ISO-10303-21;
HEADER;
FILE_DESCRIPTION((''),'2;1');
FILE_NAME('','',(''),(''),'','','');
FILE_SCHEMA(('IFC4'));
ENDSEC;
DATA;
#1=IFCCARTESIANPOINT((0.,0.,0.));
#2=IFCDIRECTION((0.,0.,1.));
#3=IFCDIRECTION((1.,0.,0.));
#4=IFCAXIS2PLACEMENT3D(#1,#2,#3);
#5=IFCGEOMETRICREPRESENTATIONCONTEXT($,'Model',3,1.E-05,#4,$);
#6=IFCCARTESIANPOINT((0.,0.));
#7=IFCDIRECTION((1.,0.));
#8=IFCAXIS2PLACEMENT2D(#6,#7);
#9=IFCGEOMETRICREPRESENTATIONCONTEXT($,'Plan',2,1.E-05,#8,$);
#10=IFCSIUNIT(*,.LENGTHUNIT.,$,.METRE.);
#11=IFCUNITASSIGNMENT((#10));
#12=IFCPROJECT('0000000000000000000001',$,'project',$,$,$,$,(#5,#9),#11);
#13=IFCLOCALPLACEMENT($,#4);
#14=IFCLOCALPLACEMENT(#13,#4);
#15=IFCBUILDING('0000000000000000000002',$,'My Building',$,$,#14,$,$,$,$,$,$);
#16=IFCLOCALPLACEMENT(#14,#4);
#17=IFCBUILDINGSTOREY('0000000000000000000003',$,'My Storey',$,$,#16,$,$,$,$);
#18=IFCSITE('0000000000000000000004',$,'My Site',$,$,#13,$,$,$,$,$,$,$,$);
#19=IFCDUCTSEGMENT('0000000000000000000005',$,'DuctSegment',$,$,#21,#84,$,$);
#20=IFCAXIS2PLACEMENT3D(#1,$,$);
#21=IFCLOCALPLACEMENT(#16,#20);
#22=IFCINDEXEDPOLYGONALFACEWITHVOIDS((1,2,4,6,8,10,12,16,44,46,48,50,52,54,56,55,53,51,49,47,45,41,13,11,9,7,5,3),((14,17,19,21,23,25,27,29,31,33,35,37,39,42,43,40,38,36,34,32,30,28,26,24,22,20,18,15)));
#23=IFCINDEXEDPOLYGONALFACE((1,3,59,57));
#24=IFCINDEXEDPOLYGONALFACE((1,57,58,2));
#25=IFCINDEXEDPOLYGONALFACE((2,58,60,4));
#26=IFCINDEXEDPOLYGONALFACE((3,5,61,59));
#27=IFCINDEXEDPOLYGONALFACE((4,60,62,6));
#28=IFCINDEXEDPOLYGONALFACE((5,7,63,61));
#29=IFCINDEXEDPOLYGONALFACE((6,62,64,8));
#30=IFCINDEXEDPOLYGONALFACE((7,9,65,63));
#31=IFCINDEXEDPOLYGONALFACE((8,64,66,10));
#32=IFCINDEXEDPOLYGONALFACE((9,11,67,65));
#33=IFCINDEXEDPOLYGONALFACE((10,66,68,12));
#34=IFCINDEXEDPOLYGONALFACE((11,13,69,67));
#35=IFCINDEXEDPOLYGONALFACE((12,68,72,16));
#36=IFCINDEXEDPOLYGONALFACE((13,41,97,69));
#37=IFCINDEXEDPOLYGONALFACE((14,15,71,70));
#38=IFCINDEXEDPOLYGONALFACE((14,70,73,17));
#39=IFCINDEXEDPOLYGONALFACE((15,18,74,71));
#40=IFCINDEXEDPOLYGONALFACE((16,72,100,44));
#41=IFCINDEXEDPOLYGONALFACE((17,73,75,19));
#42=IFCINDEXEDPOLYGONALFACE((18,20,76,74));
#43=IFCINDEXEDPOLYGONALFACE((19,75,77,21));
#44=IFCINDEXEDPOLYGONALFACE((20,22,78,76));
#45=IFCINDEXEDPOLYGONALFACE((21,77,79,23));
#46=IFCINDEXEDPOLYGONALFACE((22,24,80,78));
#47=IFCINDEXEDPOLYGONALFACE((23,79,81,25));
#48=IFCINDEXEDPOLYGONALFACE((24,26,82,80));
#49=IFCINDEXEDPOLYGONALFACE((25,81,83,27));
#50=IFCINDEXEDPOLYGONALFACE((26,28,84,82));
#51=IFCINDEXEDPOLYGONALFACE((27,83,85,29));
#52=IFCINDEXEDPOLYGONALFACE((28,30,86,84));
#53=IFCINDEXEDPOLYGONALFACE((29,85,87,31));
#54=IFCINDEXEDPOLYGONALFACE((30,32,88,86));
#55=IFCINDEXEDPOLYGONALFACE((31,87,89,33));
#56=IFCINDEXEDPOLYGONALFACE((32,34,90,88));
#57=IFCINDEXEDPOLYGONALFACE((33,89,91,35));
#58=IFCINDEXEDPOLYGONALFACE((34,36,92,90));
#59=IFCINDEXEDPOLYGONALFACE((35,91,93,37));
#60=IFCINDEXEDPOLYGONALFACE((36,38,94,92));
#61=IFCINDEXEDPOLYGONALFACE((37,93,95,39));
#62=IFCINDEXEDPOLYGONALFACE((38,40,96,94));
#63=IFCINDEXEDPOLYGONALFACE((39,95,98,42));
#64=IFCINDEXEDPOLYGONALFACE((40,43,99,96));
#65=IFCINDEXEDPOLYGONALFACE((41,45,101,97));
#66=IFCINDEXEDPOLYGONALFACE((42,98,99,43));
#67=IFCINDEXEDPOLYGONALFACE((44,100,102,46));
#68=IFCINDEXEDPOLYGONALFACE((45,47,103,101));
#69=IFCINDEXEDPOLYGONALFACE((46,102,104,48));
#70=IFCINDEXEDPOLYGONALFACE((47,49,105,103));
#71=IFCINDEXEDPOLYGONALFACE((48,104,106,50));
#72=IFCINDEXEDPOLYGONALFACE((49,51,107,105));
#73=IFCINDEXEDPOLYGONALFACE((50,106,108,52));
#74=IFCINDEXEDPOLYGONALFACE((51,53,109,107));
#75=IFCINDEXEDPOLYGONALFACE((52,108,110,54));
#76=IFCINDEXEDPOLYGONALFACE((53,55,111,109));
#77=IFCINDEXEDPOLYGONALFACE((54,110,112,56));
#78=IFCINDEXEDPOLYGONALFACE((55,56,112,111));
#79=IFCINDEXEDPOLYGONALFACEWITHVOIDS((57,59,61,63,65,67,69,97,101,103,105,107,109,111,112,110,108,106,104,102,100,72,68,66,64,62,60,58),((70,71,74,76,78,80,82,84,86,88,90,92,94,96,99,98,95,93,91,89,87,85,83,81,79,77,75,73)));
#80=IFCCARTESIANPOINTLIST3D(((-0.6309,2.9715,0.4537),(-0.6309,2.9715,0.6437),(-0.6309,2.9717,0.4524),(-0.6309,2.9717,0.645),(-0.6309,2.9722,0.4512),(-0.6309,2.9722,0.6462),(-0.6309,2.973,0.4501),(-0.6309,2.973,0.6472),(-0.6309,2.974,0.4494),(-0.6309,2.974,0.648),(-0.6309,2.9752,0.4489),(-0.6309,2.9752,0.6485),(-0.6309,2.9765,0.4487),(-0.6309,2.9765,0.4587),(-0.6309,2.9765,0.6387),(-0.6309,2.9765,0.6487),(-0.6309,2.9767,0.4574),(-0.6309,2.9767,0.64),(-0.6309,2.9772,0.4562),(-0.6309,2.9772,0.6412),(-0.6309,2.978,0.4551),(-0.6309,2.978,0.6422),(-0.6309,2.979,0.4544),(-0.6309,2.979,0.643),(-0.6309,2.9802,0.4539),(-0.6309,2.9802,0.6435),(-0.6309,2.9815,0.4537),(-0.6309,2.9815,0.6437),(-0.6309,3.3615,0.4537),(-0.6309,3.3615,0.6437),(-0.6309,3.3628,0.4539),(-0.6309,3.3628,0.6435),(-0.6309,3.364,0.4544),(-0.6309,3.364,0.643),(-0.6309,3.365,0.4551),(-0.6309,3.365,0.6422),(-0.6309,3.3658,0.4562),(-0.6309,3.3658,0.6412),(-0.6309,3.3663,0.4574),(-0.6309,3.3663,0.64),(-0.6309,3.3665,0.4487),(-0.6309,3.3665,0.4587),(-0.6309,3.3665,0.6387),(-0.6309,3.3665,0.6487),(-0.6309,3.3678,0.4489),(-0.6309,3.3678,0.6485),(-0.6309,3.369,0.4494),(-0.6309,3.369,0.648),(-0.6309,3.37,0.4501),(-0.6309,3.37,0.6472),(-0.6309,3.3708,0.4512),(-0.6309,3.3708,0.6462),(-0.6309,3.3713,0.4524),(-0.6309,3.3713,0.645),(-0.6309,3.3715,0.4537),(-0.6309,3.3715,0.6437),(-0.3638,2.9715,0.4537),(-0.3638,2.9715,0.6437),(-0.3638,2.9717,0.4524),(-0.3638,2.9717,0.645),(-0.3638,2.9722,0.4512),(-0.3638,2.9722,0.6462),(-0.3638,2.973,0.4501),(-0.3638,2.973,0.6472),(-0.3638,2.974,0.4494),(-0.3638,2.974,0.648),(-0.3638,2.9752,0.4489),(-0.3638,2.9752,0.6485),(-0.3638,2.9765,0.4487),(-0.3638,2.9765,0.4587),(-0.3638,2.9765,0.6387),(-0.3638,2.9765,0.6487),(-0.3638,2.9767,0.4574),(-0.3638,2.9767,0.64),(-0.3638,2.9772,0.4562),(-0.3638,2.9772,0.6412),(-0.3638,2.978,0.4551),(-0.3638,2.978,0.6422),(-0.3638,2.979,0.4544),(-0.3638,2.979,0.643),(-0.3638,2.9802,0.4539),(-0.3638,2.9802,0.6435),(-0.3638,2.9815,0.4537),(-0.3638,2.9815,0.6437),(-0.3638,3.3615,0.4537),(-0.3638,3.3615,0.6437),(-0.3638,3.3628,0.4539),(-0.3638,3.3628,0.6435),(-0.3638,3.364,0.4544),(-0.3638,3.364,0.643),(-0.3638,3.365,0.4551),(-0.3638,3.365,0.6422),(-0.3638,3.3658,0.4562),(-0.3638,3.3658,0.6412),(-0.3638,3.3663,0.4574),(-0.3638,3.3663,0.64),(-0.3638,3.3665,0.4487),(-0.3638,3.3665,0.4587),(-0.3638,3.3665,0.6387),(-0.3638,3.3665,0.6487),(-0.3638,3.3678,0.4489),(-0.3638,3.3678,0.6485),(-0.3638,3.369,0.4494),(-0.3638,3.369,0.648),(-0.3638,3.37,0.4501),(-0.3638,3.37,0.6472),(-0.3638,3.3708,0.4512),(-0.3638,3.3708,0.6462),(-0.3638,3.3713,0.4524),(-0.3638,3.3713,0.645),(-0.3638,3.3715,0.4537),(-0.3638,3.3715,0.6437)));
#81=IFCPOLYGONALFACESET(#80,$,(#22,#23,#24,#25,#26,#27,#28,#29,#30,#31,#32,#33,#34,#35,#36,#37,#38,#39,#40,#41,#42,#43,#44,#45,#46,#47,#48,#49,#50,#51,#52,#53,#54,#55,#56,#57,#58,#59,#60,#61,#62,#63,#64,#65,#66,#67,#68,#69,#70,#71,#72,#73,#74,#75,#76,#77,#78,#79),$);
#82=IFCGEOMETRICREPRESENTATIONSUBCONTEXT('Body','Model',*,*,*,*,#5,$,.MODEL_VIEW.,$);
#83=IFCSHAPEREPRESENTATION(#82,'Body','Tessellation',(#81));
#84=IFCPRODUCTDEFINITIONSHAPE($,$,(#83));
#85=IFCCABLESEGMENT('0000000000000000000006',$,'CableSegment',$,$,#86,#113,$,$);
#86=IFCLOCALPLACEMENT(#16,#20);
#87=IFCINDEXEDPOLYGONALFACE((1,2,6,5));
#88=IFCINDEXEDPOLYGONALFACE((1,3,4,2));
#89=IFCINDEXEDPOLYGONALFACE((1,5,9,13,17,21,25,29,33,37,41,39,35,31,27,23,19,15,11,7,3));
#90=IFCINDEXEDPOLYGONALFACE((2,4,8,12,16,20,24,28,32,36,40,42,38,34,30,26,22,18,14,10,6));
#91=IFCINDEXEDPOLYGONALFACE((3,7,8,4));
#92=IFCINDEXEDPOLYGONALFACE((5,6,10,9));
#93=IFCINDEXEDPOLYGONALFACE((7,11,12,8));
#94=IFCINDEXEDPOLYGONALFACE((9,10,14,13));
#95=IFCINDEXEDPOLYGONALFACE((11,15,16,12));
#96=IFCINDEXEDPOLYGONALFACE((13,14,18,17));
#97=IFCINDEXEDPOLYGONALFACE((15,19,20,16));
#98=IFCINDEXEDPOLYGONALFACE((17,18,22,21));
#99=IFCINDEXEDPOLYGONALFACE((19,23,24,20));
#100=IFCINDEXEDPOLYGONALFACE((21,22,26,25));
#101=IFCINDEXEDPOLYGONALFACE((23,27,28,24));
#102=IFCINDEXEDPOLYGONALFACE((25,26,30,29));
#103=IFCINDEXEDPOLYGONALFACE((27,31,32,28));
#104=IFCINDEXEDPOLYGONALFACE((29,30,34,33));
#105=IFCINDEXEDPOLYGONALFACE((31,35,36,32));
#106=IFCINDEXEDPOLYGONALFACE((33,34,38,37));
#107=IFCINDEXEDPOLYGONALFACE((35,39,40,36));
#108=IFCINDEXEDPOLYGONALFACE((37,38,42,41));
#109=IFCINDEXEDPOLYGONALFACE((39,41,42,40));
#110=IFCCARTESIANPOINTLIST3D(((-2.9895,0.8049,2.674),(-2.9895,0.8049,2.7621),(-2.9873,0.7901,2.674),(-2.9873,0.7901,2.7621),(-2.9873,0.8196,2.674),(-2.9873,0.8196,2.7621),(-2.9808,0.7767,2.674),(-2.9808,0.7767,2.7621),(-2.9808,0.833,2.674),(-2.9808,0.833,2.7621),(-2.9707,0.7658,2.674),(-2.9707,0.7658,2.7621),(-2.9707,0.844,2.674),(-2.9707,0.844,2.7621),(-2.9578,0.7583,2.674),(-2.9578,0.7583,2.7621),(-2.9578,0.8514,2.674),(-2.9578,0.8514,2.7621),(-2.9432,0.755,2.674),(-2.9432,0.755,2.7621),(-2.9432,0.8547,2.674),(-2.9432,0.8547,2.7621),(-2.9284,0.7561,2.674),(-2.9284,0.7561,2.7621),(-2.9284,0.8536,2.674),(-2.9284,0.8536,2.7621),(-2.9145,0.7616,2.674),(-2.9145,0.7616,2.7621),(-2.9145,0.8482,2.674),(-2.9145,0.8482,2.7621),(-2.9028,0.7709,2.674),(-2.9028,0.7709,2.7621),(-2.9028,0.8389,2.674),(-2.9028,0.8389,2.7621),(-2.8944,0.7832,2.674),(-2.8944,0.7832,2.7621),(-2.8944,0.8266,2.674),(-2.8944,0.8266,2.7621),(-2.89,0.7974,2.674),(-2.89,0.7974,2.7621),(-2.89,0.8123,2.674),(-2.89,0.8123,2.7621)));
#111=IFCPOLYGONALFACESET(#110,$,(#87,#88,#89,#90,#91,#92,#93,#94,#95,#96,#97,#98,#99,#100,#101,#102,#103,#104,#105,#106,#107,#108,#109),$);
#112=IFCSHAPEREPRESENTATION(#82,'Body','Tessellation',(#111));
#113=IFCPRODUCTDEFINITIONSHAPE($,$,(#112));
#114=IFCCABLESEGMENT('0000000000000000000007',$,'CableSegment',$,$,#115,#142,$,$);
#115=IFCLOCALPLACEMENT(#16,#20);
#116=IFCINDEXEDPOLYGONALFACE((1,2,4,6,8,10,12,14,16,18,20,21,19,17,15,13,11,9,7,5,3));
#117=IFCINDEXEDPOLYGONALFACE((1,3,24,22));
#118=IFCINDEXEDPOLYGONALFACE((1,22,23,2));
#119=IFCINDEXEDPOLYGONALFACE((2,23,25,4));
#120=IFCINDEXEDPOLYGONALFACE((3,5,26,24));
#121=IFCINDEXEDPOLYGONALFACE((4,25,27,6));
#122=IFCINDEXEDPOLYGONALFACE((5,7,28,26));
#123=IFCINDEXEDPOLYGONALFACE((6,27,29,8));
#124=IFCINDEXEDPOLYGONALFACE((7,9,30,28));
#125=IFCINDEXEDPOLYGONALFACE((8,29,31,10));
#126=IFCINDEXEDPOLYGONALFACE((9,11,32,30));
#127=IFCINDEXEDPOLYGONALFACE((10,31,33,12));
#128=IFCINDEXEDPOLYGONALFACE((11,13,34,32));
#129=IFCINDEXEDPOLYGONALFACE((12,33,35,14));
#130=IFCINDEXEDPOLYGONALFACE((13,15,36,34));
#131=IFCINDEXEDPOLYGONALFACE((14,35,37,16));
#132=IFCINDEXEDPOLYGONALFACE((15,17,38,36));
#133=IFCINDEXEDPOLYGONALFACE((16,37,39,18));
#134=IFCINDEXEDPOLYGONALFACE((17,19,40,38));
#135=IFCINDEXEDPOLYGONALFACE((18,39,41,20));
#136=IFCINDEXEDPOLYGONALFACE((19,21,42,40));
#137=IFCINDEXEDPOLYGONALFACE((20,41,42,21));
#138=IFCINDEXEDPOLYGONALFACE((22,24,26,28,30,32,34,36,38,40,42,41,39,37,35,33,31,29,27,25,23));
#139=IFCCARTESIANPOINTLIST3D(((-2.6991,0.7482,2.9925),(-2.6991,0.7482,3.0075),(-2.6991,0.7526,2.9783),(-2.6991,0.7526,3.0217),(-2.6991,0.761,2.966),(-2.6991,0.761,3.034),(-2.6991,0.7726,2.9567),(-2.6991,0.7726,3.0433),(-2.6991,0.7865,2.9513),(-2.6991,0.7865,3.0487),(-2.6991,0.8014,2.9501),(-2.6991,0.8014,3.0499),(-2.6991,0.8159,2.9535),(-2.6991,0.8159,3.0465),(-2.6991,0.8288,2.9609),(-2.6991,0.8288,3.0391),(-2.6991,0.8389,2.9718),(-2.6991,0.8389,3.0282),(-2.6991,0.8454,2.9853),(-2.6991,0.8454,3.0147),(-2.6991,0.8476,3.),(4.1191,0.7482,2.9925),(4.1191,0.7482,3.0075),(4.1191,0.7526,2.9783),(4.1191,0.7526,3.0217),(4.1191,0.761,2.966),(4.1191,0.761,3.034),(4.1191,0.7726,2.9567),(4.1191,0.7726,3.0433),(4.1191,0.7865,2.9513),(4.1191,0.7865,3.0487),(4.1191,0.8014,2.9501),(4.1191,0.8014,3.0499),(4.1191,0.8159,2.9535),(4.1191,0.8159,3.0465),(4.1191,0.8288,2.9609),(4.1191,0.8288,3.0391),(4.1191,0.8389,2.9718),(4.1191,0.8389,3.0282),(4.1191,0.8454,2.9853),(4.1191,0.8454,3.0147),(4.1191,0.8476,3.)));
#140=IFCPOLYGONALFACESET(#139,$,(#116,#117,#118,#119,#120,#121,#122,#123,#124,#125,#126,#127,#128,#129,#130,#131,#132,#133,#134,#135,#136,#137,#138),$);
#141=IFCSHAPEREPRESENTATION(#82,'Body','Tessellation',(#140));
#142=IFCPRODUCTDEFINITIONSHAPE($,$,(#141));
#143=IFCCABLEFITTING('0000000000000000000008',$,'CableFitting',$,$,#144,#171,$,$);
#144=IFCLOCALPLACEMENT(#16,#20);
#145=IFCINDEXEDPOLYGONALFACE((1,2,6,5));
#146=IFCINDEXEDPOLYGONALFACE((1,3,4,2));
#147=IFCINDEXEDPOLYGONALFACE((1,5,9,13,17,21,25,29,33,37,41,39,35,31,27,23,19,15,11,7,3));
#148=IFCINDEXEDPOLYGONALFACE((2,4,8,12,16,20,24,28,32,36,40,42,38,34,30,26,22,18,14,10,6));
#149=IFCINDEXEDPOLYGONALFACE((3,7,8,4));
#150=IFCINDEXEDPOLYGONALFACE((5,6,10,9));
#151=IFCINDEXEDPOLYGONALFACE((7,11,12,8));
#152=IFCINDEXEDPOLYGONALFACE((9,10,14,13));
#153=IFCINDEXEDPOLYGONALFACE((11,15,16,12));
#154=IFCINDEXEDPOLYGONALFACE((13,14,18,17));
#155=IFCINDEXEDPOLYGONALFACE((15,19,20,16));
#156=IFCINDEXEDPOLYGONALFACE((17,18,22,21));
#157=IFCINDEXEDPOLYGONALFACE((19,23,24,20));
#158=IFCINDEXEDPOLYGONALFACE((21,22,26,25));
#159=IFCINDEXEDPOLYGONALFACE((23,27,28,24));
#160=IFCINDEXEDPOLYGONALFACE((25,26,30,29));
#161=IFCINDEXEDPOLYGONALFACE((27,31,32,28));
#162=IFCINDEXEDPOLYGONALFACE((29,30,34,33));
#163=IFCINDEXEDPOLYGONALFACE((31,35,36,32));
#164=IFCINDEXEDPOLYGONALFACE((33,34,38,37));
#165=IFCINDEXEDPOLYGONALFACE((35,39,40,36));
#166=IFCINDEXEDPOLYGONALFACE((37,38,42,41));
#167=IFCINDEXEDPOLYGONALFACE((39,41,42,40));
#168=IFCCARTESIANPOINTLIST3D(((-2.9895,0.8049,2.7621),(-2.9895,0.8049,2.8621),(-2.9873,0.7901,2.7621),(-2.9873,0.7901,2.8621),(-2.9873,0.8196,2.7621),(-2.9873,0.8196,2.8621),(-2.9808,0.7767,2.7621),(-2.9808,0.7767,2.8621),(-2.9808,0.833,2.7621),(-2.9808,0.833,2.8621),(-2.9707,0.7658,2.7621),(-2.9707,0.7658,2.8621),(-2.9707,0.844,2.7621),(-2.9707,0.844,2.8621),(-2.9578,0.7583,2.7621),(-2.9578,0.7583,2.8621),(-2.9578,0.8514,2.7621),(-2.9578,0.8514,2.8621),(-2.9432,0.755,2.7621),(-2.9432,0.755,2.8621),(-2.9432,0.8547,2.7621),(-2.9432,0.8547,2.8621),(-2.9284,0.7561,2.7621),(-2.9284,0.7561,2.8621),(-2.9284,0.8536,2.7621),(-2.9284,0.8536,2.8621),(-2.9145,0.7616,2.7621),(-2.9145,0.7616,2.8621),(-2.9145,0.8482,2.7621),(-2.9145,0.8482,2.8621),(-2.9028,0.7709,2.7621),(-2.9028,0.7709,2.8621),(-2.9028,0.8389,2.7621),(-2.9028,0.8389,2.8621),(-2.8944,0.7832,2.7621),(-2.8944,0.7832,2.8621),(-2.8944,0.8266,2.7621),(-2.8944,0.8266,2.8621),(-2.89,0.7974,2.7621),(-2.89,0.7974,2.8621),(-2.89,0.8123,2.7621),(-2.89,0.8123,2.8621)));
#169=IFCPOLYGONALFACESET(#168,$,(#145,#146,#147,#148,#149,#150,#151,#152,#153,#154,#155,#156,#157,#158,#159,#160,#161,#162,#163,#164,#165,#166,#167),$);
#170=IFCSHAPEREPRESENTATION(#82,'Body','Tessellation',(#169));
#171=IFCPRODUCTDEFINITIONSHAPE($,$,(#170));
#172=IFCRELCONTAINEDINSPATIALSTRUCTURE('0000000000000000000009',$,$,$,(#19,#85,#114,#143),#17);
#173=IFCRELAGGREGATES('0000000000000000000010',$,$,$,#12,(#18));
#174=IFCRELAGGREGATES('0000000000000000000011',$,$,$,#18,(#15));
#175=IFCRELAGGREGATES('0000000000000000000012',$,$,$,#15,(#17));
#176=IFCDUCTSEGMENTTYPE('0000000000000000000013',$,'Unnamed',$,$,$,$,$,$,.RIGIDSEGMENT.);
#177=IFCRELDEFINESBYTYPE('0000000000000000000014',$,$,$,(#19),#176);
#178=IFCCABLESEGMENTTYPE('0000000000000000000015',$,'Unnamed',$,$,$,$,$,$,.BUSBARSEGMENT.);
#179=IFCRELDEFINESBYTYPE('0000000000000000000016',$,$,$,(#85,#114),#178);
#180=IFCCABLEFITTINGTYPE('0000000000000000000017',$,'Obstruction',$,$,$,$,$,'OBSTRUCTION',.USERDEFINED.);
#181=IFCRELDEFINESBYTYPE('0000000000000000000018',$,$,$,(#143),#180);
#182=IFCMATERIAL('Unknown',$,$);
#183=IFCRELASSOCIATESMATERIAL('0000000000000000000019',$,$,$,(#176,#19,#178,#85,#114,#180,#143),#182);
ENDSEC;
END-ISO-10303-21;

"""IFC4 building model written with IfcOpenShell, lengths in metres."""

from ifc_helpers import new_model, si_unit, frame, origin_with_axes, origin_2d_with_axis, place, context, subcontext, project, spatial, hollow_rectangle, circle, extrude, material, material_profile, profile_set, profile_usage, type_object, element, save


model = new_model("IFC4")

# Units and contexts
model_context = context("Model", 3, precision=1e-05, world=origin_with_axes())
plan_context = context("Plan", 2, precision=1e-05, world=origin_2d_with_axis())
body_context_1 = subcontext(model_context, "Body", "Model", "MODEL_VIEW")
ifc_project = project(units=[si_unit("LENGTHUNIT", "METRE")], contexts=[model_context, plan_context])

# Site, building, storey
site_placement = place(None, origin_with_axes())
site = spatial("IfcSite", under=ifc_project, at=site_placement, Name="My Site")
building_placement = place(site_placement, origin_with_axes())
building = spatial("IfcBuilding", under=site, at=building_placement, Name="My Building")
storey_placement = place(building_placement, origin_with_axes())
storey = spatial("IfcBuildingStorey", under=building, at=storey_placement, Name="My Storey")

# Shared definitions
ifc_material = material(Name="Unknown")

# Duct segment
ifc_material_profile_1 = material_profile(ifc_material, hollow_rectangle(XDim=0.4, YDim=0.2, WallThickness=0.005, InnerFilletRadius=0.005, OuterFilletRadius=0.005))
ifc_profile_set_1 = profile_set([ifc_material_profile_1])
duct_segment_type = type_object("IfcDuctSegmentType", Name="Unnamed", PredefinedType="RIGIDSEGMENT", material=ifc_profile_set_1)
ifc_profile_usage_1 = profile_usage(ifc_profile_set_1, cardinal=5)
duct_segment_1_placement = place(storey_placement, frame((-0.6309, 3.1715, 0.5487), z_axis=(1.0, 0.0, 0.0), x_axis=(0.0, 1.0, 0.0)))
element("IfcDuctSegment", 1, at=duct_segment_1_placement, inside=storey, type_object=duct_segment_type, material=ifc_profile_usage_1, Name="DuctSegment", context=body_context_1, shape_type="SweptSolid", body=[
    extrude(hollow_rectangle(XDim=0.4, YDim=0.2, WallThickness=0.005, InnerFilletRadius=0.005, OuterFilletRadius=0.005), origin_with_axes(), (0.0, 0.0, 1.0), 0.2671),
])

# Cable segments
ifc_material_profile_2 = material_profile(ifc_material, circle(Radius=0.05))
ifc_profile_set_2 = profile_set([ifc_material_profile_2])
ifc_profile_usage_2 = profile_usage(ifc_profile_set_2, cardinal=5)
cable_segment_type = type_object("IfcCableSegmentType", Name="Unnamed", PredefinedType="BUSBARSEGMENT", material=ifc_profile_set_2)
cable_segment_1_placement = place(storey_placement, frame((-2.9395, 0.8049, 2.7621), z_axis=(0.0, 0.0, -1.0), x_axis=(-1.0, 0.0, 0.0)))
element("IfcCableSegment", 2, at=cable_segment_1_placement, inside=storey, type_object=cable_segment_type, material=ifc_profile_usage_2, Name="CableSegment", context=body_context_1, shape_type="SweptSolid", body=[
    extrude(circle(Radius=0.05), origin_with_axes(), (0.0, 0.0, 1.0), 0.0881),
])
ifc_profile_usage_3 = profile_usage(ifc_profile_set_2, cardinal=5)
cable_segment_2_placement = place(storey_placement, frame((-2.6991, 0.7976, 3.0), z_axis=(1.0, -0.000001, 0.000001), x_axis=(0.000001, 1.0, 0.0)))
element("IfcCableSegment", 3, at=cable_segment_2_placement, inside=storey, type_object=cable_segment_type, material=ifc_profile_usage_3, Name="CableSegment", context=body_context_1, shape_type="SweptSolid", body=[
    extrude(circle(Radius=0.05), origin_with_axes(), (0.0, 0.0, 1.0), 6.8182),
])

# Cable fitting
ifc_material_profile_3 = material_profile(ifc_material, circle(Radius=0.05))
ifc_profile_set_3 = profile_set([ifc_material_profile_3])
ifc_profile_usage_4 = profile_usage(ifc_profile_set_3, cardinal=5)
cable_fitting_type_1 = type_object("IfcCableFittingType", Name="Obstruction", ElementType="OBSTRUCTION", PredefinedType="USERDEFINED", material=ifc_profile_set_3)
cable_fitting_1_placement = place(storey_placement, frame((-2.9395, 0.8049, 2.8621), z_axis=(0.0, 0.0, -1.0), x_axis=(-1.0, 0.0, 0.0)))
element("IfcCableFitting", 4, at=cable_fitting_1_placement, inside=storey, type_object=cable_fitting_type_1, material=ifc_profile_usage_4, Name="CableFitting", context=body_context_1, shape_type="SweptSolid", body=[
    extrude(circle(Radius=0.05), origin_with_axes(), (0.0, 0.0, 1.0), 0.1),
])

save(model, "model.ifc")
